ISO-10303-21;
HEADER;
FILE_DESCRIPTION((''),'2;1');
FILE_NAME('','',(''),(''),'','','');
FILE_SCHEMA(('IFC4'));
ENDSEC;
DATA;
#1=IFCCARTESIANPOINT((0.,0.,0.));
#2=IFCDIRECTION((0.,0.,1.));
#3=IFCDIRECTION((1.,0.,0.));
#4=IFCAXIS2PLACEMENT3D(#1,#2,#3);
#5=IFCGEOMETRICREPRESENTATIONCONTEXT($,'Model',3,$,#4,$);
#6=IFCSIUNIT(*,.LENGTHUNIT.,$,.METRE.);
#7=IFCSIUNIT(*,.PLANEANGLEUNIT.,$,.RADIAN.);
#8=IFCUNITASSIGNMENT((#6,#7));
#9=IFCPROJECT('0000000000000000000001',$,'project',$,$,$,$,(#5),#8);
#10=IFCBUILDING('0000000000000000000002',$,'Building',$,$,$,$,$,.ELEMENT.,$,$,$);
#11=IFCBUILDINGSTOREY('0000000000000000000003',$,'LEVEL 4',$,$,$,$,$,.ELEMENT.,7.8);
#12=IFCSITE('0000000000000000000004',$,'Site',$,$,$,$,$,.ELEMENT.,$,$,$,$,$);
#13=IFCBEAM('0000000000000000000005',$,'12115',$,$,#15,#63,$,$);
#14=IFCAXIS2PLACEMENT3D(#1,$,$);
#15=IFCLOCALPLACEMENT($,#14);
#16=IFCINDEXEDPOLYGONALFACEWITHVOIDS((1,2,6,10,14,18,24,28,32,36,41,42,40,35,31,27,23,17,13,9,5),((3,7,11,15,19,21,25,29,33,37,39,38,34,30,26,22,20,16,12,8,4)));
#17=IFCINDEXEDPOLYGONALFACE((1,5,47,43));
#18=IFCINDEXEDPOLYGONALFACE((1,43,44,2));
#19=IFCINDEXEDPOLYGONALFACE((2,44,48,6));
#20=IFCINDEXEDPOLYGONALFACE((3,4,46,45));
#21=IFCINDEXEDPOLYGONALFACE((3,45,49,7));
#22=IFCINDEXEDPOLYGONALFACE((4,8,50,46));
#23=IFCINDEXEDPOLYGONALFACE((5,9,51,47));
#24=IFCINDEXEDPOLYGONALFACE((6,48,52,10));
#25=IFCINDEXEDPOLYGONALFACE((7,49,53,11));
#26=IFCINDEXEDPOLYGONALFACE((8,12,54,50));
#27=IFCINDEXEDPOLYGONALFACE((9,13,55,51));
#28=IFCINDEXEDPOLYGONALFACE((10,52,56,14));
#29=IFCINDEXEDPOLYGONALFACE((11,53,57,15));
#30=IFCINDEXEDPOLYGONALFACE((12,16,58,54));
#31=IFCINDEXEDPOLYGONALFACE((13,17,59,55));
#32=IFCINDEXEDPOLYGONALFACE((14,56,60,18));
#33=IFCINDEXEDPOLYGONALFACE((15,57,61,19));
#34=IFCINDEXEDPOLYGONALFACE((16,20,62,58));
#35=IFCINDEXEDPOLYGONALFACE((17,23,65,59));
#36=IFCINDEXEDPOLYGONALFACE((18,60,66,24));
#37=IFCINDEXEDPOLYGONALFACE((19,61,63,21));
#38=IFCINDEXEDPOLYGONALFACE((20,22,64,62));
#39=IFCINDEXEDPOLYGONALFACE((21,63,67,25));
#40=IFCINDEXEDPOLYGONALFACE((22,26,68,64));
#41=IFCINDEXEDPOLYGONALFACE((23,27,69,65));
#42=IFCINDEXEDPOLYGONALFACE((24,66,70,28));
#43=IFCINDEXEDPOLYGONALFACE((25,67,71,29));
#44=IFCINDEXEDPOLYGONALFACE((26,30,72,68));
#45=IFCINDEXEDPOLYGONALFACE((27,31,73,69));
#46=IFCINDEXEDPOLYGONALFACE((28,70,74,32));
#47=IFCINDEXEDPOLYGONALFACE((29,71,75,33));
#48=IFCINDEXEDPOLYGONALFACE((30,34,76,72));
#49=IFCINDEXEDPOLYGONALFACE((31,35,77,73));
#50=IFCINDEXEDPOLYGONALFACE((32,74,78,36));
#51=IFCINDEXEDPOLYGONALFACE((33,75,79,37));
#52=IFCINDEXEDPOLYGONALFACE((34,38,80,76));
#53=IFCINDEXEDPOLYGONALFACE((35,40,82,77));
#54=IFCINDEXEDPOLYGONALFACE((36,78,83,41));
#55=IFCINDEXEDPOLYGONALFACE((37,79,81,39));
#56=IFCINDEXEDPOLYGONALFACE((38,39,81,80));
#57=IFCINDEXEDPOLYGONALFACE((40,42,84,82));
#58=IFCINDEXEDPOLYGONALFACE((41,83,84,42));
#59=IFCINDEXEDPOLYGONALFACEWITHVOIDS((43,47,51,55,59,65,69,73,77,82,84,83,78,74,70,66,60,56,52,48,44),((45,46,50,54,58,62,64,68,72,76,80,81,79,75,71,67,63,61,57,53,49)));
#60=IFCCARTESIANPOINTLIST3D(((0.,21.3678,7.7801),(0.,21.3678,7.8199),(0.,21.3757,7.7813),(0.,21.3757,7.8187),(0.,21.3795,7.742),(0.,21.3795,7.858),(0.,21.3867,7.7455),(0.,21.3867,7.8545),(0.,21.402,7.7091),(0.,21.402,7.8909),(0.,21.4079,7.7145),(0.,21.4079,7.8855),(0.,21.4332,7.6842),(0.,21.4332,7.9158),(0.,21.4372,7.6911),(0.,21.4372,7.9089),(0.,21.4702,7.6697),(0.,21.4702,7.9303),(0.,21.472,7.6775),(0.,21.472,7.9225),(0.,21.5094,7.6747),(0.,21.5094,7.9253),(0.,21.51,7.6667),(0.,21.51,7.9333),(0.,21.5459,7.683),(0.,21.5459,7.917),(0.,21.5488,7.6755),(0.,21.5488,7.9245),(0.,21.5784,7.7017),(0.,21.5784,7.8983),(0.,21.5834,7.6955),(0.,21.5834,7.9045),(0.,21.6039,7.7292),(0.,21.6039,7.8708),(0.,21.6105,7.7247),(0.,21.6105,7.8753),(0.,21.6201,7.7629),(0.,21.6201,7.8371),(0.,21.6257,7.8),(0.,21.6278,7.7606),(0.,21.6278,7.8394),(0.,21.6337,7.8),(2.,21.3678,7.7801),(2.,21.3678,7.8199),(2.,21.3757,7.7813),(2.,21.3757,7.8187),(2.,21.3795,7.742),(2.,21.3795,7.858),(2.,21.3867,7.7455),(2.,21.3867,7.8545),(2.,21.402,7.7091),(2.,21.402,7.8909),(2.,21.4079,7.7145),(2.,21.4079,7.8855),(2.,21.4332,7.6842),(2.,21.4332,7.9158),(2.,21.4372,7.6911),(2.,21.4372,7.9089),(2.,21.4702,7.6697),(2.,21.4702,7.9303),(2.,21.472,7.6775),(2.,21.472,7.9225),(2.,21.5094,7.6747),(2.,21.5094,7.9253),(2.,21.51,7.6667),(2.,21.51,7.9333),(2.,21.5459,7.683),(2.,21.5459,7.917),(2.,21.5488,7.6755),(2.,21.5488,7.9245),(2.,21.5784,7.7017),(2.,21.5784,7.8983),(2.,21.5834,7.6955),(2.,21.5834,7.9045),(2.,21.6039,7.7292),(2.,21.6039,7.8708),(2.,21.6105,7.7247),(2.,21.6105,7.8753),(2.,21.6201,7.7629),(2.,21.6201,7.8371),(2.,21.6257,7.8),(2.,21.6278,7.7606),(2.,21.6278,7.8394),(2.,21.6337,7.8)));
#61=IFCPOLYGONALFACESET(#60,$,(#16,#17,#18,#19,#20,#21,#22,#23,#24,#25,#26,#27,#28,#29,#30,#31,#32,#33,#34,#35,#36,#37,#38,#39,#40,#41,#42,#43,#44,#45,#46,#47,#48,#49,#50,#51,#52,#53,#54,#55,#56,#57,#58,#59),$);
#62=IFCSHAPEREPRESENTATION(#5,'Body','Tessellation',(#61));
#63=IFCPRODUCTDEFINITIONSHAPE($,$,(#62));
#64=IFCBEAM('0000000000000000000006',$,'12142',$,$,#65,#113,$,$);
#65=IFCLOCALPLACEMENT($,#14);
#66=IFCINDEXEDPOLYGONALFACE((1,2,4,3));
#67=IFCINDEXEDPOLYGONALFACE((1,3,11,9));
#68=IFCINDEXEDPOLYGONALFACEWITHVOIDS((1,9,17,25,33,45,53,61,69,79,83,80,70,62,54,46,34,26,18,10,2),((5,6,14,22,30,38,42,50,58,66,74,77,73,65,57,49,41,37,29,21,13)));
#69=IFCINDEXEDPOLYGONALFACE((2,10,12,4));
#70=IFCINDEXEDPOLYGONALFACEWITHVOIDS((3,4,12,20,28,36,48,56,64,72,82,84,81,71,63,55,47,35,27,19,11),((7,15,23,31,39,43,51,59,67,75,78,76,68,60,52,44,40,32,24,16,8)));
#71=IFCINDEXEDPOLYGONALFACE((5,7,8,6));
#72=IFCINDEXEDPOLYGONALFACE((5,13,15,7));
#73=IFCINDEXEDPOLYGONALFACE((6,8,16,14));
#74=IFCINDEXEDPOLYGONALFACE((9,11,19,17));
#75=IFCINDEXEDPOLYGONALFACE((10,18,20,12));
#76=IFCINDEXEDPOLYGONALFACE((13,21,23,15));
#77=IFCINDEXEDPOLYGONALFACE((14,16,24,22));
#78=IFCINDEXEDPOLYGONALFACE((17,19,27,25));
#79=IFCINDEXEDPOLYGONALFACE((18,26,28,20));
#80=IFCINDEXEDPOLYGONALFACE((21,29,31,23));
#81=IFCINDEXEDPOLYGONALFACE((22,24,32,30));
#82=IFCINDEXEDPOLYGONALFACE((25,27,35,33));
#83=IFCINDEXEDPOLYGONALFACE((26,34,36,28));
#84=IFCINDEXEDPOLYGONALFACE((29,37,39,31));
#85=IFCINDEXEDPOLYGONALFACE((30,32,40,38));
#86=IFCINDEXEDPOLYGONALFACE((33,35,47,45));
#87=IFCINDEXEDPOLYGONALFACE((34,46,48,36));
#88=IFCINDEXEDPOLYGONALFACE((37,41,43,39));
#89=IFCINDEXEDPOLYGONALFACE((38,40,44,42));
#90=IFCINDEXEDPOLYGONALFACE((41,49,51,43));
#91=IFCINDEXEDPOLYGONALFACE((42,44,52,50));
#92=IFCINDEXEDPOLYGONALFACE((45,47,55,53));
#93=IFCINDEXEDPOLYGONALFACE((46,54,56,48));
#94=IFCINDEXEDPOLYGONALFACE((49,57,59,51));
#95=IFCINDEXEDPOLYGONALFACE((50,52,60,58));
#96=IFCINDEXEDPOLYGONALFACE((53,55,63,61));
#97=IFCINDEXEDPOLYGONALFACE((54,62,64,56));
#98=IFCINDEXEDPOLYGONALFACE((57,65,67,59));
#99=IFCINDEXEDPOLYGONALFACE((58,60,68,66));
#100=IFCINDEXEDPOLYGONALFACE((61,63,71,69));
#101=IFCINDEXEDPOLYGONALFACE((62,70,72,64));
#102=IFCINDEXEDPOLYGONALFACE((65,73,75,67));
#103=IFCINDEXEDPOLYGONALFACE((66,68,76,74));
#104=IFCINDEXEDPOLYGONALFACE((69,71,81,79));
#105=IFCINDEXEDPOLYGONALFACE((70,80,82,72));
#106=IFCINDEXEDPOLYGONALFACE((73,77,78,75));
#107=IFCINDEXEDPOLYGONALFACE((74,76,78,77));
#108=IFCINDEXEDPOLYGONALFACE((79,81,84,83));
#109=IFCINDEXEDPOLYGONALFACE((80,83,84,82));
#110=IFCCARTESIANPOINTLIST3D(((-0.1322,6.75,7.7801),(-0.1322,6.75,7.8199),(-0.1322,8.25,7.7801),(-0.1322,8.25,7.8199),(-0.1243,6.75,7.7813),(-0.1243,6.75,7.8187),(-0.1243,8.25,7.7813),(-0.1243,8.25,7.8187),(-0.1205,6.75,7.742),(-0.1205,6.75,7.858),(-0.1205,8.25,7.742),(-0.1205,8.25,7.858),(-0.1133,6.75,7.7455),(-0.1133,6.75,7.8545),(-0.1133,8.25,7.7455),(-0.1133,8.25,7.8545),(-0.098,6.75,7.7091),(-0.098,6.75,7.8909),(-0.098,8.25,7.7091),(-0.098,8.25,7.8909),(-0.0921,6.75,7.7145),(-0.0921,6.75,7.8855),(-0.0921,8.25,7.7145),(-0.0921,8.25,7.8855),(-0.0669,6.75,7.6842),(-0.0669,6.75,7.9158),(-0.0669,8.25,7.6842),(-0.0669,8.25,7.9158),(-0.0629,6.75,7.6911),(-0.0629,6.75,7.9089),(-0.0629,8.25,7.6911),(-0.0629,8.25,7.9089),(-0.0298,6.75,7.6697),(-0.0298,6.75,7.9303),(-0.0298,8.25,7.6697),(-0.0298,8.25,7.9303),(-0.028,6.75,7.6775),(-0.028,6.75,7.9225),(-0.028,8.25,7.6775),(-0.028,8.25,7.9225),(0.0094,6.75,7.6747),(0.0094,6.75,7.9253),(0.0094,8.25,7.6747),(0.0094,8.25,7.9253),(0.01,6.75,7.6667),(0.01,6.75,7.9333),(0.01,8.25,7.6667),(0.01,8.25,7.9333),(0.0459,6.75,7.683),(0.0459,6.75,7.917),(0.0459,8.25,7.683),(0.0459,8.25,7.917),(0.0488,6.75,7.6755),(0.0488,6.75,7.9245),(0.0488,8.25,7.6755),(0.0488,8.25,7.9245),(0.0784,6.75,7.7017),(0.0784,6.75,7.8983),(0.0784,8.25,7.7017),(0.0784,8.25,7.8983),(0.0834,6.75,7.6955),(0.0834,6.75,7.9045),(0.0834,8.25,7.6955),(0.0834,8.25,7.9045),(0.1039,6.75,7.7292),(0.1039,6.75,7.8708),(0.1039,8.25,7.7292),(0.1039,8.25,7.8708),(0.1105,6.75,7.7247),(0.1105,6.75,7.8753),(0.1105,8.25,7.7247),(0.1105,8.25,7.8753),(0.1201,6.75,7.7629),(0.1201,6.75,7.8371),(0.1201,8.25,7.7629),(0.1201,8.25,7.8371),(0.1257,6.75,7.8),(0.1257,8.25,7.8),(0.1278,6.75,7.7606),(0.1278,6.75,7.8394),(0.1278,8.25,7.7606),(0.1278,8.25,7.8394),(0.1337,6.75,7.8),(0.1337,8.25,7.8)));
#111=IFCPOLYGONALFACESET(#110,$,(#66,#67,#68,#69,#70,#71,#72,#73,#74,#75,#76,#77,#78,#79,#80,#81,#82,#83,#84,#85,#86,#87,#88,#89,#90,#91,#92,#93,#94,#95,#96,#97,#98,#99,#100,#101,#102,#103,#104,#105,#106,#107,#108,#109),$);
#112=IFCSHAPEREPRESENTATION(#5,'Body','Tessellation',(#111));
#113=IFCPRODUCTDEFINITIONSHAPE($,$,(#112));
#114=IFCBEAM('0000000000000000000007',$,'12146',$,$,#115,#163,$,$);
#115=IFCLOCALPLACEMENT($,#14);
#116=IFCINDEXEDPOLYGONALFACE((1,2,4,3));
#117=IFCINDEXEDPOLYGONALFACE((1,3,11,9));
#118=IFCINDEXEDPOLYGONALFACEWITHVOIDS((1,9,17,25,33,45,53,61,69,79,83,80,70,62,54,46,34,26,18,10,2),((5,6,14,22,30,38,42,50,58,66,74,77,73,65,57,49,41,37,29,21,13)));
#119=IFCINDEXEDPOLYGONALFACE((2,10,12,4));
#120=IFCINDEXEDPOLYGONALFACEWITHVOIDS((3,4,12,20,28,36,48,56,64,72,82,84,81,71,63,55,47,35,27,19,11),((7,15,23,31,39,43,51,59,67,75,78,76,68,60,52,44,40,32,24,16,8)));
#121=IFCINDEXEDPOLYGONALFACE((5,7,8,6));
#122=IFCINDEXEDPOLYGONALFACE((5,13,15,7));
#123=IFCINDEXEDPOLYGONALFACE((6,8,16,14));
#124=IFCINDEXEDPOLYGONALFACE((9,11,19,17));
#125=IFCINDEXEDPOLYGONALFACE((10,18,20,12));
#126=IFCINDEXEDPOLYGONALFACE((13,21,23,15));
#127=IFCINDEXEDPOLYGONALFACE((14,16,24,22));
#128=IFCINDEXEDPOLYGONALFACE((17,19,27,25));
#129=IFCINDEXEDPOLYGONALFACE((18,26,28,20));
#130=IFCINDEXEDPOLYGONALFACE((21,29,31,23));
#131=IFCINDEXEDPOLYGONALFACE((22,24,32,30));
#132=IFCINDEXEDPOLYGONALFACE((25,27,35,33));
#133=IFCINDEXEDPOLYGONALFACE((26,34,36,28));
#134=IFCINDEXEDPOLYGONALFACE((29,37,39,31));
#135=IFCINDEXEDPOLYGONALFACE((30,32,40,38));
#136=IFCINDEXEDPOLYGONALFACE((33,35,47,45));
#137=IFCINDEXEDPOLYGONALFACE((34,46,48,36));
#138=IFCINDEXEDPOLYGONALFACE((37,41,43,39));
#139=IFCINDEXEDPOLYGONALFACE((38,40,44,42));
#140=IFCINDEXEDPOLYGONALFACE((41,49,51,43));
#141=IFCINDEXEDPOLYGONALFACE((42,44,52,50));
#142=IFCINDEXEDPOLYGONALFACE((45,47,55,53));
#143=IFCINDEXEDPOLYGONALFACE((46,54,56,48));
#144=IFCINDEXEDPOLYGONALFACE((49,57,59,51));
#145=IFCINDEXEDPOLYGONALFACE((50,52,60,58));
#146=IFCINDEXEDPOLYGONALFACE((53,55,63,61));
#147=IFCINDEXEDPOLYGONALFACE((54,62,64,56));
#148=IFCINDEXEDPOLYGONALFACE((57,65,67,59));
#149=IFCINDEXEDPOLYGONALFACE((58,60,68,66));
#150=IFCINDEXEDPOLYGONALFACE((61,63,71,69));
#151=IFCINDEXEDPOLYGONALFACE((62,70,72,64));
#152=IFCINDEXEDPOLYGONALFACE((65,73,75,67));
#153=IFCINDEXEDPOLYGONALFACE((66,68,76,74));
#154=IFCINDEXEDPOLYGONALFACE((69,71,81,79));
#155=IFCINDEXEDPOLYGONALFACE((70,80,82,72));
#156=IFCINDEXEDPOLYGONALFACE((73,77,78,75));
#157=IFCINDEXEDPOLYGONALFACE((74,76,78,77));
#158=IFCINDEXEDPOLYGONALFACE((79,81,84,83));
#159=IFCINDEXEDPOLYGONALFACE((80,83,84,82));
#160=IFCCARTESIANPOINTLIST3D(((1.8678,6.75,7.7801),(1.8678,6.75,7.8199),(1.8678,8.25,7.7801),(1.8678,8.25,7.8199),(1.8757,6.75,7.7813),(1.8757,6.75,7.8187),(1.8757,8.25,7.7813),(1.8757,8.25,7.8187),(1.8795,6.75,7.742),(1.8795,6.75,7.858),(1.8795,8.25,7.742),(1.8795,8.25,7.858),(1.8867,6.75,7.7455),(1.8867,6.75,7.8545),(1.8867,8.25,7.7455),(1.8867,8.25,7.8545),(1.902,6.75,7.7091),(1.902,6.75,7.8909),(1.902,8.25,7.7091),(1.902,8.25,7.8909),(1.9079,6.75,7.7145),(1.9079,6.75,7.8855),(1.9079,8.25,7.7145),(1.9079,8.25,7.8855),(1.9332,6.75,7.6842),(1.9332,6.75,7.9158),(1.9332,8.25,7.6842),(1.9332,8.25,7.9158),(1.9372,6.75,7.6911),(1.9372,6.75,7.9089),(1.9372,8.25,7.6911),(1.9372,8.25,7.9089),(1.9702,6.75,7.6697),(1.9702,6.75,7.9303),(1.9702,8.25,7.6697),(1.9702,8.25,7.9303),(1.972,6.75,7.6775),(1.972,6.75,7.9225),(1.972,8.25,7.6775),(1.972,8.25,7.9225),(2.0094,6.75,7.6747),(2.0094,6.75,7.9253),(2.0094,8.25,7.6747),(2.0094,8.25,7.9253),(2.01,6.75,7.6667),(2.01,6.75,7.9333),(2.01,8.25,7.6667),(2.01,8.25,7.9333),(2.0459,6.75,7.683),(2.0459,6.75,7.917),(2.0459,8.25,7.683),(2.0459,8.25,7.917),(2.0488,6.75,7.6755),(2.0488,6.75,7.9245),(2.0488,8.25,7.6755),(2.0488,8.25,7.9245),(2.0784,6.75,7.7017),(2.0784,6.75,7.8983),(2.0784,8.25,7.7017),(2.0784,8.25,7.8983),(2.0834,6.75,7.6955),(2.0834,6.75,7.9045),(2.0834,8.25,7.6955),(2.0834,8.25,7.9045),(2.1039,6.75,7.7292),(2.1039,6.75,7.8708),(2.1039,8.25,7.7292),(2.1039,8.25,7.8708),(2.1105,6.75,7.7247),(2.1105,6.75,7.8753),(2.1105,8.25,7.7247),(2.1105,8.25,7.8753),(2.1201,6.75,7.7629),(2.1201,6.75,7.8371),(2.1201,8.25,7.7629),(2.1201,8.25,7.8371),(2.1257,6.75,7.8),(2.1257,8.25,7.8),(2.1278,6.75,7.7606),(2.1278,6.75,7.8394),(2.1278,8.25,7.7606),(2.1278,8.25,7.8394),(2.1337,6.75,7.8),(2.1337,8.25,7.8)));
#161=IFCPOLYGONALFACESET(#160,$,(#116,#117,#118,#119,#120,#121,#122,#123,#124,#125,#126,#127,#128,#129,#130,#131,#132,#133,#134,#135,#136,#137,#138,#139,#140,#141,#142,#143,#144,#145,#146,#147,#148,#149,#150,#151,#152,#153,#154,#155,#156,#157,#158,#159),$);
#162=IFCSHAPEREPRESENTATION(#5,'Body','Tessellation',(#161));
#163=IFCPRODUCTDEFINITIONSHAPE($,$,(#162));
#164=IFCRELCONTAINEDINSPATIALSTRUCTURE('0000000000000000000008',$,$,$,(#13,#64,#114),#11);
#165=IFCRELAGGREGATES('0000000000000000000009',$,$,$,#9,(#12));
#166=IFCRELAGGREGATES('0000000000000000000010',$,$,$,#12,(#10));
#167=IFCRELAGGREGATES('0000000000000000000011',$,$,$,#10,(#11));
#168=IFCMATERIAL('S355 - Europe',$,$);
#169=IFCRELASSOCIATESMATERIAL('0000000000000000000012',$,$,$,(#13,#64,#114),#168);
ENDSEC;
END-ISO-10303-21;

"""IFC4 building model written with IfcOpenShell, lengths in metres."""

from ifc_helpers import new_model, si_unit, frame, origin_with_axes, origin_2d_with_axis, place, context, project, spatial, hollow_circle, extrude, material, material_profile, profile_set, profile_usage, element, save


model = new_model("IFC4")

# Units and contexts
model_context = context("Model", 3, world=origin_with_axes())
ifc_project = project(units=[si_unit("LENGTHUNIT", "METRE"), si_unit("PLANEANGLEUNIT", "RADIAN")], contexts=[model_context])

# Site, building, storey
site = spatial("IfcSite", under=ifc_project, Name="Site", CompositionType="ELEMENT")
building = spatial("IfcBuilding", under=site, Name="Building", CompositionType="ELEMENT")
storey = spatial("IfcBuildingStorey", under=building, Name="LEVEL 4", CompositionType="ELEMENT", Elevation=7.8)

# Shared definitions
ifc_material = material(Name="S355 - Europe")

# Beams
ifc_material_profile_1 = material_profile(ifc_material, hollow_circle(Radius=0.1337, WallThickness=0.008, at=origin_2d_with_axis()))
ifc_profile_set_1 = profile_set([ifc_material_profile_1])
ifc_profile_usage_1 = profile_usage(ifc_profile_set_1, cardinal=10)
beam_1_placement = place(None, frame((0.0, 21.5, 7.8), z_axis=(1.0, 0.0, 0.0), x_axis=(0.0, 1.0, 0.0)))
element("IfcBeam", 1, at=beam_1_placement, inside=storey, material=ifc_profile_usage_1, Name="12115", context=model_context, shape_type="SweptSolid", body=[
    extrude(hollow_circle(Radius=0.1337, WallThickness=0.008, at=origin_2d_with_axis()), origin_with_axes(), (0.0, 0.0, 1.0), 2.0),
])
ifc_material_profile_2 = material_profile(ifc_material, hollow_circle(Radius=0.1337, WallThickness=0.008, at=origin_2d_with_axis()))
ifc_profile_set_2 = profile_set([ifc_material_profile_2])
ifc_profile_usage_2 = profile_usage(ifc_profile_set_2, cardinal=10)
beam_2_placement = place(None, frame((0.0, 8.25, 7.8), z_axis=(0.0, -1.0, 0.0), x_axis=(1.0, 0.0, 0.0)))
element("IfcBeam", 2, at=beam_2_placement, inside=storey, material=ifc_profile_usage_2, Name="12142", context=model_context, shape_type="SweptSolid", body=[
    extrude(hollow_circle(Radius=0.1337, WallThickness=0.008, at=origin_2d_with_axis()), origin_with_axes(), (0.0, 0.0, 1.0), 1.5),
])
ifc_material_profile_3 = material_profile(ifc_material, hollow_circle(Radius=0.1337, WallThickness=0.008, at=origin_2d_with_axis()))
ifc_profile_set_3 = profile_set([ifc_material_profile_3])
ifc_profile_usage_3 = profile_usage(ifc_profile_set_3, cardinal=10)
beam_3_placement = place(None, frame((2.0, 8.25, 7.8), z_axis=(0.0, -1.0, 0.0), x_axis=(1.0, 0.0, 0.0)))
element("IfcBeam", 3, at=beam_3_placement, inside=storey, material=ifc_profile_usage_3, Name="12146", context=model_context, shape_type="SweptSolid", body=[
    extrude(hollow_circle(Radius=0.1337, WallThickness=0.008, at=origin_2d_with_axis()), origin_with_axes(), (0.0, 0.0, 1.0), 1.5),
])

save(model, "model.ifc")
